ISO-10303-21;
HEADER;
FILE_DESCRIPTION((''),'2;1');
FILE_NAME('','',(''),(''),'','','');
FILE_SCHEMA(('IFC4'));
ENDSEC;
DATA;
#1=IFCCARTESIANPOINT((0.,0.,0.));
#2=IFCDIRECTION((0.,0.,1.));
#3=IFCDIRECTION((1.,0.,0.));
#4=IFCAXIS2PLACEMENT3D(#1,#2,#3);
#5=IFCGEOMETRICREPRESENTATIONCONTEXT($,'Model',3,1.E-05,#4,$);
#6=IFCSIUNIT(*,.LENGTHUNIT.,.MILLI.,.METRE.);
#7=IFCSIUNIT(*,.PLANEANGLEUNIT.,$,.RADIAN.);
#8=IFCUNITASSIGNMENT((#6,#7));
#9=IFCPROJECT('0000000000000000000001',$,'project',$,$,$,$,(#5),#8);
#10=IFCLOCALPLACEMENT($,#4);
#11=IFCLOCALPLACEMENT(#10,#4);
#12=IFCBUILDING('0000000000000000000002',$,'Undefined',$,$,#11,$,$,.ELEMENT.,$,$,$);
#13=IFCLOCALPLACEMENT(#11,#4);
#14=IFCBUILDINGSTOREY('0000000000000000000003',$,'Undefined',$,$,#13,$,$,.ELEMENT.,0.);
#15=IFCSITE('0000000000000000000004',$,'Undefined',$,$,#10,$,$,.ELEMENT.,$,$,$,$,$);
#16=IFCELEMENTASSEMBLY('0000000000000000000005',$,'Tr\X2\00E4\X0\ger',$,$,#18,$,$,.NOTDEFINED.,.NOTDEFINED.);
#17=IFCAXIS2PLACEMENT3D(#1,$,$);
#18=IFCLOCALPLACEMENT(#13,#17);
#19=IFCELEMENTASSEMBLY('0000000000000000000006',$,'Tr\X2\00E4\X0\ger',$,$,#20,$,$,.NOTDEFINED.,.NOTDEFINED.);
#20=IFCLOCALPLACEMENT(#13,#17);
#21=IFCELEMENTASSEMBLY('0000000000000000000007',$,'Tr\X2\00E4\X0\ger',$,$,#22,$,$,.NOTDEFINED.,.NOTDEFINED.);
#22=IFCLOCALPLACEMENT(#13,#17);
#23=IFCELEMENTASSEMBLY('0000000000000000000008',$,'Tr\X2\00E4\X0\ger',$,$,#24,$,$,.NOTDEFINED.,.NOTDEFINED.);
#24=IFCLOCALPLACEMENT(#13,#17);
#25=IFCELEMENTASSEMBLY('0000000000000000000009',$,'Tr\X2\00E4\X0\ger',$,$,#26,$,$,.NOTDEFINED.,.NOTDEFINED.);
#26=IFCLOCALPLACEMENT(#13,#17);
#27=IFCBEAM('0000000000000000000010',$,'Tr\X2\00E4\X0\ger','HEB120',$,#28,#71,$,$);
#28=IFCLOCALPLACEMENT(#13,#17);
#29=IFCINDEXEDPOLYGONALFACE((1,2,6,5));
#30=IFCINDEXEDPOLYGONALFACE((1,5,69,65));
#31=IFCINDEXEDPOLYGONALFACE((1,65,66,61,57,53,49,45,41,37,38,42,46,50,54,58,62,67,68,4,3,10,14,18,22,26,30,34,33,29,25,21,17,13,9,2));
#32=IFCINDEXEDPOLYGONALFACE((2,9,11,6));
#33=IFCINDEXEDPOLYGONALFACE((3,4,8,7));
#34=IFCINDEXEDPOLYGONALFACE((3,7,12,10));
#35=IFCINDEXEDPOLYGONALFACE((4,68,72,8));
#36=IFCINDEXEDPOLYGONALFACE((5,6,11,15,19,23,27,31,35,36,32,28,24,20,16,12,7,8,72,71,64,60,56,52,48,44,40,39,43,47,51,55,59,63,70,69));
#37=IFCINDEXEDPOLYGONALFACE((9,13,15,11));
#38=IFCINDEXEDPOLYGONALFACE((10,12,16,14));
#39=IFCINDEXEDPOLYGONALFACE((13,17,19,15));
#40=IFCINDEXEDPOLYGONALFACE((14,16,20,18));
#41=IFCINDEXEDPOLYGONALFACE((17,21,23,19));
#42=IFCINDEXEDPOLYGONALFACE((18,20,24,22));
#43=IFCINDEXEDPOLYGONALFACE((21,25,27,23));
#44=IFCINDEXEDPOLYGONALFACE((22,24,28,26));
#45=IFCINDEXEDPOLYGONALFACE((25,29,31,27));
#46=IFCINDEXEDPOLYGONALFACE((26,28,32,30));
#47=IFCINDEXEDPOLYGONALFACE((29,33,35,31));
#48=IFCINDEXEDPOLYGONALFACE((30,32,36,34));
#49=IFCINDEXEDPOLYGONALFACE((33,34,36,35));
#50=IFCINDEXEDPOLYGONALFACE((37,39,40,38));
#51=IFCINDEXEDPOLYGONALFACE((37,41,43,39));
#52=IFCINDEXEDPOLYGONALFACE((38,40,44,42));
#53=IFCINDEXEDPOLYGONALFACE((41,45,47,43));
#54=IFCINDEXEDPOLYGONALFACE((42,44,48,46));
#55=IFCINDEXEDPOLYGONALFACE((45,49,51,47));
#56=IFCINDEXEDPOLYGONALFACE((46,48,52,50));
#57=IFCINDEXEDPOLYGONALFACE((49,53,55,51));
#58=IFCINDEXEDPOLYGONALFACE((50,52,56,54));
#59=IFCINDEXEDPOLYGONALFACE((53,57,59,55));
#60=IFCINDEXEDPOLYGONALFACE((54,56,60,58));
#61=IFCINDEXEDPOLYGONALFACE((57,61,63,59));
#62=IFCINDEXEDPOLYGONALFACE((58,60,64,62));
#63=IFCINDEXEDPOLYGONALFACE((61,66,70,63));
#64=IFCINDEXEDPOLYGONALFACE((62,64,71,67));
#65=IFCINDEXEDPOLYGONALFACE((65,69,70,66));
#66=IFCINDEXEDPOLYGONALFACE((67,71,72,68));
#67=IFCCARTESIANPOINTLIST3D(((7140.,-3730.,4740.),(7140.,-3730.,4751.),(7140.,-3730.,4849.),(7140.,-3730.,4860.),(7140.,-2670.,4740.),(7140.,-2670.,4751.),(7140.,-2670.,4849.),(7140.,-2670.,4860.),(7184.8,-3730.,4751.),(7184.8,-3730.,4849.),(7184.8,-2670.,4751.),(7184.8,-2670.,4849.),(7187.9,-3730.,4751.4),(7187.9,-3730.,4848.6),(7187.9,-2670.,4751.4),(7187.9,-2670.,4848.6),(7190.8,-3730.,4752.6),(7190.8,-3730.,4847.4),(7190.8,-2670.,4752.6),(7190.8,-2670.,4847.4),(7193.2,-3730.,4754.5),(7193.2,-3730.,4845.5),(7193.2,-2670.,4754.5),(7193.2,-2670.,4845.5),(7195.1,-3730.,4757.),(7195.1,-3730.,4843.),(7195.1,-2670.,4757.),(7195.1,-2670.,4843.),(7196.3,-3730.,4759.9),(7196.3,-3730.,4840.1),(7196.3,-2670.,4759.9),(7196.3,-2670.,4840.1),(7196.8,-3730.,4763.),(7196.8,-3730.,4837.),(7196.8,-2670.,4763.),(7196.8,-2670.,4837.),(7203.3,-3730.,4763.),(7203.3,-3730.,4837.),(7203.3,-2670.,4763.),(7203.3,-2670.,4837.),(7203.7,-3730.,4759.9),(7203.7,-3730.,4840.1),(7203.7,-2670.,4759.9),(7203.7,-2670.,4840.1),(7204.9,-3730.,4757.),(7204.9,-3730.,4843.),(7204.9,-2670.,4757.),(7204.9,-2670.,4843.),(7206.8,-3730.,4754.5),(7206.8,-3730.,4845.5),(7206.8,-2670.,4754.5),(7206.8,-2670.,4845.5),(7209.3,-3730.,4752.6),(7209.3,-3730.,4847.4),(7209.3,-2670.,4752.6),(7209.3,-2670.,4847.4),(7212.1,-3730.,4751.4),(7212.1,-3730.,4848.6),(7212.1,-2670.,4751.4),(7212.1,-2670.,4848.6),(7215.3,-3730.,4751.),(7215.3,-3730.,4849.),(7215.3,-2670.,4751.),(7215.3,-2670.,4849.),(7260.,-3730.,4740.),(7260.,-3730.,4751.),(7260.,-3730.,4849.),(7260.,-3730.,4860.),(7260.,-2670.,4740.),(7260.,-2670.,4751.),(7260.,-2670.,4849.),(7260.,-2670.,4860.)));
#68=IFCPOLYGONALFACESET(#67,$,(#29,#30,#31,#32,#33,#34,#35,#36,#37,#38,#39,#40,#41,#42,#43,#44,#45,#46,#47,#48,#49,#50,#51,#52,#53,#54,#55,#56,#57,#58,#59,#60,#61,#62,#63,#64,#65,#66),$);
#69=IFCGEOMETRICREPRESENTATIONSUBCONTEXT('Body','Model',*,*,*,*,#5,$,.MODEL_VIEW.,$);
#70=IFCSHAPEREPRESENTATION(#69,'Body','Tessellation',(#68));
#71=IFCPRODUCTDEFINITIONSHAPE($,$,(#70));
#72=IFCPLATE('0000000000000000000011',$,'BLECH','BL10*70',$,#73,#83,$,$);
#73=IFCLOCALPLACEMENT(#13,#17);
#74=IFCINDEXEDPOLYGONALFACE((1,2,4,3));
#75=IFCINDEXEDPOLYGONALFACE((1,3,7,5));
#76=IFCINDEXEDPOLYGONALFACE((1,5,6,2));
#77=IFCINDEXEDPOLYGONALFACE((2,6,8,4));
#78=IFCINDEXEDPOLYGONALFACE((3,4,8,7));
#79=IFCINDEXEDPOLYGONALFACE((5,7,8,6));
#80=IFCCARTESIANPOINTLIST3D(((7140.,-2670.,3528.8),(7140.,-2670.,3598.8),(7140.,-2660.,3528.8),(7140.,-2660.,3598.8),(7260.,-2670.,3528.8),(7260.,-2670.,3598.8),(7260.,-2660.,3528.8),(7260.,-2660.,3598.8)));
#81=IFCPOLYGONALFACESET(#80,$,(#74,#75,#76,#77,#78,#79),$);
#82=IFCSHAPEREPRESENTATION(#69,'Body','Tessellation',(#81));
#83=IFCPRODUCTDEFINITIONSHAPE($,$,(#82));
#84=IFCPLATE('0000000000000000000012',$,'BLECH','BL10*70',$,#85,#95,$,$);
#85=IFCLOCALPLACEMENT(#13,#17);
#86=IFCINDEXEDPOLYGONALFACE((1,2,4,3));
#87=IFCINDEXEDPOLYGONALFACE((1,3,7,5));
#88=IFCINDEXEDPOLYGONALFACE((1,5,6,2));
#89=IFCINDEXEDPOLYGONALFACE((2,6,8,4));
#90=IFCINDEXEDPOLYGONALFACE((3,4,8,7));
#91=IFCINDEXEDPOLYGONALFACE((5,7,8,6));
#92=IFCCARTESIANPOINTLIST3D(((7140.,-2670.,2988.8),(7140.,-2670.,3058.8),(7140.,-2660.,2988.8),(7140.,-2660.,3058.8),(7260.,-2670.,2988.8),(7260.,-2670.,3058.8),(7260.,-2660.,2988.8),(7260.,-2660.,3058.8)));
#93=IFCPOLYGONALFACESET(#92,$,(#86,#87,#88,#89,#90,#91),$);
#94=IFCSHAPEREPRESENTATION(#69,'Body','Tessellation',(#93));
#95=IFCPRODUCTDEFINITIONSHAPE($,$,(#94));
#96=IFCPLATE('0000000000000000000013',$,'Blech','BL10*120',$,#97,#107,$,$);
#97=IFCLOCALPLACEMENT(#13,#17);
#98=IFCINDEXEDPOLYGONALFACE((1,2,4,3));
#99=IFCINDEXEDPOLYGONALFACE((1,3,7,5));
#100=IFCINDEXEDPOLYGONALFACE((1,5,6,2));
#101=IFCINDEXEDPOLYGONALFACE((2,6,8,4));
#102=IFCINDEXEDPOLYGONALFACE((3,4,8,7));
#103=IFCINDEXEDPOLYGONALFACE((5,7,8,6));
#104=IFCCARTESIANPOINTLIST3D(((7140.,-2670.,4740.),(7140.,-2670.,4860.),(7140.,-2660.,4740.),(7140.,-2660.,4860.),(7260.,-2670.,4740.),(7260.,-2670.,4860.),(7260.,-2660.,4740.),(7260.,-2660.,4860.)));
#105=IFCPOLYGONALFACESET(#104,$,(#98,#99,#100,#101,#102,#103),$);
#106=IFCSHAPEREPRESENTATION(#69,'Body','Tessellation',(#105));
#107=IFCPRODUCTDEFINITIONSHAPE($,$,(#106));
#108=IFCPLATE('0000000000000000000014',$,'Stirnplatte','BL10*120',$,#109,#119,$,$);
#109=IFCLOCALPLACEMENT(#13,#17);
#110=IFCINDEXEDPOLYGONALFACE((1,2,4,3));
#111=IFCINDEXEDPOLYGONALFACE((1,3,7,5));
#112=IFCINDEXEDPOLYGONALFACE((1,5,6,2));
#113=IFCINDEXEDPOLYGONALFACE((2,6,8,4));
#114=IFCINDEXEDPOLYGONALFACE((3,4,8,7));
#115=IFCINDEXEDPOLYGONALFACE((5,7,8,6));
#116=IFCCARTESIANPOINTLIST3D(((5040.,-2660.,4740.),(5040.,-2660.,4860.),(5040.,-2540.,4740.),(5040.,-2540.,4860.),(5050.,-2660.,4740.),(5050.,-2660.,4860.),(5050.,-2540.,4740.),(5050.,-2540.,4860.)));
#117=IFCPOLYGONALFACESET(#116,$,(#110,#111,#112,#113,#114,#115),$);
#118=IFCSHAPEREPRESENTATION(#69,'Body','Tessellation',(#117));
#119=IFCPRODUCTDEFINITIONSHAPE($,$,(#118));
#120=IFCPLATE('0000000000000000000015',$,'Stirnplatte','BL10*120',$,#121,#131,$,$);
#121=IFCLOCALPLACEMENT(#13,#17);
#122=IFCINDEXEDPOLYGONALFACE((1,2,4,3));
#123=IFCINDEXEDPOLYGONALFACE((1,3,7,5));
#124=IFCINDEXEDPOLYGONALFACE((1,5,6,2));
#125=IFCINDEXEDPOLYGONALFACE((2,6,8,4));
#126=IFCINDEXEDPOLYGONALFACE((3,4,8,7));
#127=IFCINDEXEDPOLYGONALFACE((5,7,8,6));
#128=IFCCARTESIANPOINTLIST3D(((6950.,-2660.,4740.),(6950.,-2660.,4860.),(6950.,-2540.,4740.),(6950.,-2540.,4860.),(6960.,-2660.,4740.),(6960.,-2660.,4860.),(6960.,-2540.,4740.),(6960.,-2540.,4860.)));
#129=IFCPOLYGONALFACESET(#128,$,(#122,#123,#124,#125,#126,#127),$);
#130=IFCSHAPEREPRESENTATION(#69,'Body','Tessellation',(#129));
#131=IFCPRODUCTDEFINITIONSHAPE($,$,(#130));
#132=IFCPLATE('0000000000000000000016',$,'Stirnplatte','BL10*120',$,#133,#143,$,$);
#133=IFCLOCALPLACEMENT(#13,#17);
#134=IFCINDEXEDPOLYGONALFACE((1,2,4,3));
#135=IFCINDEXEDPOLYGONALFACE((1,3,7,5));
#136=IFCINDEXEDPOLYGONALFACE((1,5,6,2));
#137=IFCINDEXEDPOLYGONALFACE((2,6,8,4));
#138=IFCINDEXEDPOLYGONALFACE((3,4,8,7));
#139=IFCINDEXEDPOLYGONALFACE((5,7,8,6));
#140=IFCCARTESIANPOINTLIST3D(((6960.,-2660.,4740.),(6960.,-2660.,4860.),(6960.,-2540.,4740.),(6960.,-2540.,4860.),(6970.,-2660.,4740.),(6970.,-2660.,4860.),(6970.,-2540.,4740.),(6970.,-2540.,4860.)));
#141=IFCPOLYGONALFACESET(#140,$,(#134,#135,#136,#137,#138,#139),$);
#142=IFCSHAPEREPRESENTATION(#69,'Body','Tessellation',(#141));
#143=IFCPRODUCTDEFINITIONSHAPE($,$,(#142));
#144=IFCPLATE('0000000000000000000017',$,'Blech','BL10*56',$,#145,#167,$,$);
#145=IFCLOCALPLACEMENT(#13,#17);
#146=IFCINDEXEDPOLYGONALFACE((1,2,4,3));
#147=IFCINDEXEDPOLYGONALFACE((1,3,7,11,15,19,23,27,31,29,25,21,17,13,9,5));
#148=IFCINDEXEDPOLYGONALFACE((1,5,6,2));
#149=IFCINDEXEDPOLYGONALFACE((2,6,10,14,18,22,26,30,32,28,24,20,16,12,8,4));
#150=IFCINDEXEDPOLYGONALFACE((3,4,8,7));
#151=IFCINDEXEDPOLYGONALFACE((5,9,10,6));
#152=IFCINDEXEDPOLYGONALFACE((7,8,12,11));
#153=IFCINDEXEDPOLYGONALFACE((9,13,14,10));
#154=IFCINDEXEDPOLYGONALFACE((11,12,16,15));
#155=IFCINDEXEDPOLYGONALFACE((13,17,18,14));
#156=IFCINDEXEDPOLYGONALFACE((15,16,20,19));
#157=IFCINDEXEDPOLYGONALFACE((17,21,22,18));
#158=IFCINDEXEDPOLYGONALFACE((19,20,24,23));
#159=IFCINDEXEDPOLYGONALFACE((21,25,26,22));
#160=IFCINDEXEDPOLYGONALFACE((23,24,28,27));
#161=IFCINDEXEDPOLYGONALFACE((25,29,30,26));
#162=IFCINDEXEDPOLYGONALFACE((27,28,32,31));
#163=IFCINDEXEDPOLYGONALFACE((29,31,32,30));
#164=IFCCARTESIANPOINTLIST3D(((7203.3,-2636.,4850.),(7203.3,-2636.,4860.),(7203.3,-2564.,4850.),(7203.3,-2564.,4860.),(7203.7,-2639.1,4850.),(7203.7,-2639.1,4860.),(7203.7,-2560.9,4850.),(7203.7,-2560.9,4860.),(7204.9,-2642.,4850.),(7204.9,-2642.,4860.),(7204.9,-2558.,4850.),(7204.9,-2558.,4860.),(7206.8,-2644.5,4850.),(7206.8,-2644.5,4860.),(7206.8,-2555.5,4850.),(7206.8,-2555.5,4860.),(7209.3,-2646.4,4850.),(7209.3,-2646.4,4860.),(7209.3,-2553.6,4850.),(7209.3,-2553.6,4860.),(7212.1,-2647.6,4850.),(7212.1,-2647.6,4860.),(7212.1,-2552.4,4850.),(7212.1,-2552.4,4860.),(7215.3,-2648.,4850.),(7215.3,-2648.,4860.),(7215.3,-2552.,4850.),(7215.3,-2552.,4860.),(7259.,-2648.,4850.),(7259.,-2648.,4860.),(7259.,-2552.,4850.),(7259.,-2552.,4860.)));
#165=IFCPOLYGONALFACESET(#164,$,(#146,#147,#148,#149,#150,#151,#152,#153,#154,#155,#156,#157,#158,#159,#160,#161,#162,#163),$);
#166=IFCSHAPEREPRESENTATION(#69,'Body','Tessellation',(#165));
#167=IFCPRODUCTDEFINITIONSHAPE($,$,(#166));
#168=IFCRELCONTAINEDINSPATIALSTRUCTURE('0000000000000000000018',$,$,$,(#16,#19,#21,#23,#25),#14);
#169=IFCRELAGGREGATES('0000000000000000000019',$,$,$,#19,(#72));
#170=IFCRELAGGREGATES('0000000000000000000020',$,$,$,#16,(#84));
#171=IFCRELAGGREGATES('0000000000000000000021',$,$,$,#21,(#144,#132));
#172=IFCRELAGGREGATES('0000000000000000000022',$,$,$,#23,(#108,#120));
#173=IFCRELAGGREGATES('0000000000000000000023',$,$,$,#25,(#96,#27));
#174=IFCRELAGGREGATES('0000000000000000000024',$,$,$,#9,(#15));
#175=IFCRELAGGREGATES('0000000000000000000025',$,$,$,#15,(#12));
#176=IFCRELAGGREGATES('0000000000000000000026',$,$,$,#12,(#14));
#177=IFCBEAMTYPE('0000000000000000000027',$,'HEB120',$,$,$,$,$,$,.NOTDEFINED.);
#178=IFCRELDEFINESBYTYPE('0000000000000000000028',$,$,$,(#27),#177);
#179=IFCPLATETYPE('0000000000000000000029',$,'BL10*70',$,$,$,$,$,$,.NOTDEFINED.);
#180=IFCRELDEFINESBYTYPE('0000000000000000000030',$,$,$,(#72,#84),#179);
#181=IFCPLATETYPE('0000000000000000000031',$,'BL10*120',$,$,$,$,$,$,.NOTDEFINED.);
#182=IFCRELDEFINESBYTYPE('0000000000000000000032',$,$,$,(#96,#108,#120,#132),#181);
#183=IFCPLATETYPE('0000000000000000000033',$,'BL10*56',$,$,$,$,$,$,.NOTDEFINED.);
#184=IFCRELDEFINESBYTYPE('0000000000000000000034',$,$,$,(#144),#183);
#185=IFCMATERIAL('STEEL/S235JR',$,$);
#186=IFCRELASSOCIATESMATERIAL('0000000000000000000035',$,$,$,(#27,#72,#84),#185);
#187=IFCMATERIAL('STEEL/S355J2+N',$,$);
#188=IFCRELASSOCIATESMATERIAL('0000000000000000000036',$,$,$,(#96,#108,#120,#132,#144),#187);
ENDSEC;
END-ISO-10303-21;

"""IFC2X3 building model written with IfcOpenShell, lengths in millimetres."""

from ifc_helpers import new_model, si_unit, frame, frame_2d, origin_with_axes, origin_2d_with_axis, place, context, subcontext, project, spatial, polyline, circle_curve, parameter, trimmed, segment, composite_curve, i_section, outline, extrude, clip, halfspace, material, type_object, element, aggregate, save


model = new_model("IFC2X3")

# Units and contexts
model_context = context("Model", 3, precision=1e-05, world=origin_with_axes())
body_context = subcontext(model_context, "Body", "Model", "MODEL_VIEW")
ifc_project = project(units=[si_unit("LENGTHUNIT", "METRE", prefix="MILLI"), si_unit("PLANEANGLEUNIT", "RADIAN")], contexts=[model_context])

# Site, building, storey
site_placement = place(None, origin_with_axes())
site = spatial("IfcSite", under=ifc_project, at=site_placement, Name="Undefined", CompositionType="ELEMENT")
building_placement = place(site_placement, origin_with_axes())
building = spatial("IfcBuilding", under=site, at=building_placement, Name="Undefined", CompositionType="ELEMENT")
storey_placement = place(building_placement, origin_with_axes())
storey = spatial("IfcBuildingStorey", under=building, at=storey_placement, Name="Undefined", CompositionType="ELEMENT", Elevation=0.0)

# Element assemblies, beam
assembly_1_placement = place(storey_placement, origin_with_axes())
assembly_1 = element("IfcElementAssembly", 1, at=assembly_1_placement, inside=storey, Name="Träger", AssemblyPlace="NOTDEFINED", PredefinedType="NOTDEFINED")
ifc_material_1 = material(Name="STEEL/S235JR")
assembly_2_placement = place(storey_placement, origin_with_axes())
assembly_2 = element("IfcElementAssembly", 2, at=assembly_2_placement, inside=storey, Name="Träger", AssemblyPlace="NOTDEFINED", PredefinedType="NOTDEFINED")
beam_type_1 = type_object("IfcBeamType", Name="HEB120", PredefinedType="NOTDEFINED")
assembly_3_placement = place(storey_placement, origin_with_axes())
assembly_3 = element("IfcElementAssembly", 3, at=assembly_3_placement, inside=storey, Name="Träger", AssemblyPlace="NOTDEFINED", PredefinedType="NOTDEFINED")
assembly_4_placement = place(storey_placement, origin_with_axes())
assembly_4 = element("IfcElementAssembly", 4, at=assembly_4_placement, inside=storey, Name="Träger", AssemblyPlace="NOTDEFINED", PredefinedType="NOTDEFINED")
assembly_5_placement = place(storey_placement, origin_with_axes())
assembly_5 = element("IfcElementAssembly", 5, at=assembly_5_placement, inside=storey, Name="Träger", AssemblyPlace="NOTDEFINED", PredefinedType="NOTDEFINED")
beam_1_placement = place(assembly_5_placement, frame((7200.0, -2670.0, 4800.0), z_axis=(0.0, 0.0, 1.0), x_axis=(0.0, -1.0, 0.0)))
beam_1 = element("IfcBeam", 6, at=beam_1_placement, type_object=beam_type_1, material=ifc_material_1, Name="Träger", Description="HEB120", context=body_context, shape_type="Clipping", body=[
    clip(clip(extrude(i_section(OverallWidth=120.0, OverallDepth=120.0, WebThickness=6.5, FlangeThickness=11.0, FilletRadius=12.0, at=origin_2d_with_axis()), frame((1060.0, 0.0, 0.0), z_axis=(-1.0, 0.0, 0.0), x_axis=(0.0, -1.0, 0.0)), (0.0, 0.0, 1.0), 1060.0), halfspace(frame((1060.0, 0.0, -60.0), z_axis=(-1.0, 0.0, 0.0), x_axis=(0.0, 1.0, 0.0)), True)), halfspace(frame((0.0, 0.0, -60.0), z_axis=(1.0, 0.0, 0.0), x_axis=(0.0, -1.0, 0.0)), True)),
])

# Plates
plate_type_1 = type_object("IfcPlateType", Name="BL10*70", PredefinedType="NOTDEFINED")
plate_1_placement = place(assembly_2_placement, frame((7140.0, -2665.0, 3598.8), z_axis=(0.0, 1.0, 0.0), x_axis=(1.0, 0.0, 0.0)))
plate_1 = element("IfcPlate", 7, at=plate_1_placement, type_object=plate_type_1, material=ifc_material_1, Name="BLECH", Description="BL10*70", context=body_context, shape_type="SweptSolid", body=[
    extrude(outline(polyline([(0.0, 0.0), (120.0, 0.0), (120.0, 70.0), (0.0, 70.0), (0.0, 0.0)])), frame((0.0, 0.0, -5.0), z_axis=(0.0, 0.0, 1.0), x_axis=(1.0, 0.0, 0.0)), (0.0, 0.0, 1.0), 10.0),
])
aggregate(assembly_2, [plate_1])
plate_2_placement = place(assembly_1_placement, frame((7140.0, -2665.0, 3058.8), z_axis=(0.0, 1.0, 0.0), x_axis=(1.0, 0.0, 0.0)))
plate_2 = element("IfcPlate", 8, at=plate_2_placement, type_object=plate_type_1, material=ifc_material_1, Name="BLECH", Description="BL10*70", context=body_context, shape_type="SweptSolid", body=[
    extrude(outline(polyline([(0.0, 0.0), (120.0, 0.0), (120.0, 70.0), (0.0, 70.0), (0.0, 0.0)])), frame((0.0, 0.0, -5.0), z_axis=(0.0, 0.0, 1.0), x_axis=(1.0, 0.0, 0.0)), (0.0, 0.0, 1.0), 10.0),
])
aggregate(assembly_1, [plate_2])
ifc_material_2 = material(Name="STEEL/S355J2+N")
plate_type_2 = type_object("IfcPlateType", Name="BL10*120", PredefinedType="NOTDEFINED")
plate_3_placement = place(assembly_5_placement, frame((7200.0, -2665.0, 4740.0), z_axis=(0.0, -1.0, 0.0), x_axis=(0.0, 0.0, 1.0)))
plate_3 = element("IfcPlate", 9, at=plate_3_placement, type_object=plate_type_2, material=ifc_material_2, Name="Blech", Description="BL10*120", context=body_context, shape_type="SweptSolid", body=[
    extrude(outline(polyline([(0.0, -60.0), (0.0, 60.0), (120.0, 60.0), (120.0, -60.0), (0.0, -60.0)])), frame((0.0, 0.0, -5.0), z_axis=(0.0, 0.0, 1.0), x_axis=(1.0, 0.0, 0.0)), (0.0, 0.0, 1.0), 10.0),
])
plate_4_placement = place(assembly_4_placement, frame((5045.0, -2600.0, 4740.0), z_axis=(1.0, 0.0, 0.0), x_axis=(0.0, 0.0, 1.0)))
plate_4 = element("IfcPlate", 10, at=plate_4_placement, type_object=plate_type_2, material=ifc_material_2, Name="Stirnplatte", Description="BL10*120", context=body_context, shape_type="SweptSolid", body=[
    extrude(outline(polyline([(0.0, -60.0), (0.0, 60.0), (120.0, 60.0), (120.0, -60.0), (0.0, -60.0)])), frame((0.0, 0.0, -5.0), z_axis=(0.0, 0.0, 1.0), x_axis=(1.0, 0.0, 0.0)), (0.0, 0.0, 1.0), 10.0),
])
plate_5_placement = place(assembly_4_placement, frame((6955.0, -2600.0, 4740.0), z_axis=(-1.0, 0.0, 0.0), x_axis=(0.0, 0.0, 1.0)))
plate_5 = element("IfcPlate", 11, at=plate_5_placement, type_object=plate_type_2, material=ifc_material_2, Name="Stirnplatte", Description="BL10*120", context=body_context, shape_type="SweptSolid", body=[
    extrude(outline(polyline([(0.0, -60.0), (0.0, 60.0), (120.0, 60.0), (120.0, -60.0), (0.0, -60.0)])), frame((0.0, 0.0, -5.0), z_axis=(0.0, 0.0, 1.0), x_axis=(1.0, 0.0, 0.0)), (0.0, 0.0, 1.0), 10.0),
])
plate_6_placement = place(assembly_3_placement, frame((6965.0, -2600.0, 4740.0), z_axis=(-1.0, 0.0, 0.0), x_axis=(0.0, 0.0, 1.0)))
plate_6 = element("IfcPlate", 12, at=plate_6_placement, type_object=plate_type_2, material=ifc_material_2, Name="Stirnplatte", Description="BL10*120", context=body_context, shape_type="SweptSolid", body=[
    extrude(outline(polyline([(0.0, -60.0), (0.0, 60.0), (120.0, 60.0), (120.0, -60.0), (0.0, -60.0)])), frame((0.0, 0.0, -5.0), z_axis=(0.0, 0.0, 1.0), x_axis=(1.0, 0.0, 0.0)), (0.0, 0.0, 1.0), 10.0),
])
plate_type_3 = type_object("IfcPlateType", Name="BL10*56", PredefinedType="NOTDEFINED")
plate_7_placement = place(assembly_3_placement, frame((7203.3, -2648.0, 4855.0), z_axis=(0.0, 0.0, 1.0), x_axis=(1.0, 0.0, 0.0)))
plate_7 = element("IfcPlate", 13, at=plate_7_placement, type_object=plate_type_3, material=ifc_material_2, Name="Blech", Description="BL10*56", context=body_context, shape_type="SweptSolid", body=[
    extrude(outline(composite_curve([segment(trimmed(circle_curve(frame_2d((12.0, 12.0), x_axis=(-1.0, 0.0)), 12.0), [parameter(0.0)], [parameter(1.570796)], True, "PARAMETER"), True, "CONTINUOUS"), segment(polyline([(12.0, 0.0), (55.8, 0.0), (55.8, 96.0), (12.0, 96.0)]), True, "CONTINUOUS"), segment(trimmed(circle_curve(frame_2d((12.0, 84.0), x_axis=(0.0, 1.0)), 12.0), [parameter(0.0)], [parameter(1.570796)], True, "PARAMETER"), True, "CONTINUOUS"), segment(polyline([(0.0, 84.0), (0.0, 12.0)]), True, "CONTINUOUS")], self_intersect=True)), frame((0.0, 0.0, -5.0), z_axis=(0.0, 0.0, 1.0), x_axis=(1.0, 0.0, 0.0)), (0.0, 0.0, 1.0), 10.0),
])

aggregate(assembly_3, [plate_7, plate_6])

aggregate(assembly_4, [plate_4, plate_5])

aggregate(assembly_5, [plate_3, beam_1])

save(model, "model.ifc")
